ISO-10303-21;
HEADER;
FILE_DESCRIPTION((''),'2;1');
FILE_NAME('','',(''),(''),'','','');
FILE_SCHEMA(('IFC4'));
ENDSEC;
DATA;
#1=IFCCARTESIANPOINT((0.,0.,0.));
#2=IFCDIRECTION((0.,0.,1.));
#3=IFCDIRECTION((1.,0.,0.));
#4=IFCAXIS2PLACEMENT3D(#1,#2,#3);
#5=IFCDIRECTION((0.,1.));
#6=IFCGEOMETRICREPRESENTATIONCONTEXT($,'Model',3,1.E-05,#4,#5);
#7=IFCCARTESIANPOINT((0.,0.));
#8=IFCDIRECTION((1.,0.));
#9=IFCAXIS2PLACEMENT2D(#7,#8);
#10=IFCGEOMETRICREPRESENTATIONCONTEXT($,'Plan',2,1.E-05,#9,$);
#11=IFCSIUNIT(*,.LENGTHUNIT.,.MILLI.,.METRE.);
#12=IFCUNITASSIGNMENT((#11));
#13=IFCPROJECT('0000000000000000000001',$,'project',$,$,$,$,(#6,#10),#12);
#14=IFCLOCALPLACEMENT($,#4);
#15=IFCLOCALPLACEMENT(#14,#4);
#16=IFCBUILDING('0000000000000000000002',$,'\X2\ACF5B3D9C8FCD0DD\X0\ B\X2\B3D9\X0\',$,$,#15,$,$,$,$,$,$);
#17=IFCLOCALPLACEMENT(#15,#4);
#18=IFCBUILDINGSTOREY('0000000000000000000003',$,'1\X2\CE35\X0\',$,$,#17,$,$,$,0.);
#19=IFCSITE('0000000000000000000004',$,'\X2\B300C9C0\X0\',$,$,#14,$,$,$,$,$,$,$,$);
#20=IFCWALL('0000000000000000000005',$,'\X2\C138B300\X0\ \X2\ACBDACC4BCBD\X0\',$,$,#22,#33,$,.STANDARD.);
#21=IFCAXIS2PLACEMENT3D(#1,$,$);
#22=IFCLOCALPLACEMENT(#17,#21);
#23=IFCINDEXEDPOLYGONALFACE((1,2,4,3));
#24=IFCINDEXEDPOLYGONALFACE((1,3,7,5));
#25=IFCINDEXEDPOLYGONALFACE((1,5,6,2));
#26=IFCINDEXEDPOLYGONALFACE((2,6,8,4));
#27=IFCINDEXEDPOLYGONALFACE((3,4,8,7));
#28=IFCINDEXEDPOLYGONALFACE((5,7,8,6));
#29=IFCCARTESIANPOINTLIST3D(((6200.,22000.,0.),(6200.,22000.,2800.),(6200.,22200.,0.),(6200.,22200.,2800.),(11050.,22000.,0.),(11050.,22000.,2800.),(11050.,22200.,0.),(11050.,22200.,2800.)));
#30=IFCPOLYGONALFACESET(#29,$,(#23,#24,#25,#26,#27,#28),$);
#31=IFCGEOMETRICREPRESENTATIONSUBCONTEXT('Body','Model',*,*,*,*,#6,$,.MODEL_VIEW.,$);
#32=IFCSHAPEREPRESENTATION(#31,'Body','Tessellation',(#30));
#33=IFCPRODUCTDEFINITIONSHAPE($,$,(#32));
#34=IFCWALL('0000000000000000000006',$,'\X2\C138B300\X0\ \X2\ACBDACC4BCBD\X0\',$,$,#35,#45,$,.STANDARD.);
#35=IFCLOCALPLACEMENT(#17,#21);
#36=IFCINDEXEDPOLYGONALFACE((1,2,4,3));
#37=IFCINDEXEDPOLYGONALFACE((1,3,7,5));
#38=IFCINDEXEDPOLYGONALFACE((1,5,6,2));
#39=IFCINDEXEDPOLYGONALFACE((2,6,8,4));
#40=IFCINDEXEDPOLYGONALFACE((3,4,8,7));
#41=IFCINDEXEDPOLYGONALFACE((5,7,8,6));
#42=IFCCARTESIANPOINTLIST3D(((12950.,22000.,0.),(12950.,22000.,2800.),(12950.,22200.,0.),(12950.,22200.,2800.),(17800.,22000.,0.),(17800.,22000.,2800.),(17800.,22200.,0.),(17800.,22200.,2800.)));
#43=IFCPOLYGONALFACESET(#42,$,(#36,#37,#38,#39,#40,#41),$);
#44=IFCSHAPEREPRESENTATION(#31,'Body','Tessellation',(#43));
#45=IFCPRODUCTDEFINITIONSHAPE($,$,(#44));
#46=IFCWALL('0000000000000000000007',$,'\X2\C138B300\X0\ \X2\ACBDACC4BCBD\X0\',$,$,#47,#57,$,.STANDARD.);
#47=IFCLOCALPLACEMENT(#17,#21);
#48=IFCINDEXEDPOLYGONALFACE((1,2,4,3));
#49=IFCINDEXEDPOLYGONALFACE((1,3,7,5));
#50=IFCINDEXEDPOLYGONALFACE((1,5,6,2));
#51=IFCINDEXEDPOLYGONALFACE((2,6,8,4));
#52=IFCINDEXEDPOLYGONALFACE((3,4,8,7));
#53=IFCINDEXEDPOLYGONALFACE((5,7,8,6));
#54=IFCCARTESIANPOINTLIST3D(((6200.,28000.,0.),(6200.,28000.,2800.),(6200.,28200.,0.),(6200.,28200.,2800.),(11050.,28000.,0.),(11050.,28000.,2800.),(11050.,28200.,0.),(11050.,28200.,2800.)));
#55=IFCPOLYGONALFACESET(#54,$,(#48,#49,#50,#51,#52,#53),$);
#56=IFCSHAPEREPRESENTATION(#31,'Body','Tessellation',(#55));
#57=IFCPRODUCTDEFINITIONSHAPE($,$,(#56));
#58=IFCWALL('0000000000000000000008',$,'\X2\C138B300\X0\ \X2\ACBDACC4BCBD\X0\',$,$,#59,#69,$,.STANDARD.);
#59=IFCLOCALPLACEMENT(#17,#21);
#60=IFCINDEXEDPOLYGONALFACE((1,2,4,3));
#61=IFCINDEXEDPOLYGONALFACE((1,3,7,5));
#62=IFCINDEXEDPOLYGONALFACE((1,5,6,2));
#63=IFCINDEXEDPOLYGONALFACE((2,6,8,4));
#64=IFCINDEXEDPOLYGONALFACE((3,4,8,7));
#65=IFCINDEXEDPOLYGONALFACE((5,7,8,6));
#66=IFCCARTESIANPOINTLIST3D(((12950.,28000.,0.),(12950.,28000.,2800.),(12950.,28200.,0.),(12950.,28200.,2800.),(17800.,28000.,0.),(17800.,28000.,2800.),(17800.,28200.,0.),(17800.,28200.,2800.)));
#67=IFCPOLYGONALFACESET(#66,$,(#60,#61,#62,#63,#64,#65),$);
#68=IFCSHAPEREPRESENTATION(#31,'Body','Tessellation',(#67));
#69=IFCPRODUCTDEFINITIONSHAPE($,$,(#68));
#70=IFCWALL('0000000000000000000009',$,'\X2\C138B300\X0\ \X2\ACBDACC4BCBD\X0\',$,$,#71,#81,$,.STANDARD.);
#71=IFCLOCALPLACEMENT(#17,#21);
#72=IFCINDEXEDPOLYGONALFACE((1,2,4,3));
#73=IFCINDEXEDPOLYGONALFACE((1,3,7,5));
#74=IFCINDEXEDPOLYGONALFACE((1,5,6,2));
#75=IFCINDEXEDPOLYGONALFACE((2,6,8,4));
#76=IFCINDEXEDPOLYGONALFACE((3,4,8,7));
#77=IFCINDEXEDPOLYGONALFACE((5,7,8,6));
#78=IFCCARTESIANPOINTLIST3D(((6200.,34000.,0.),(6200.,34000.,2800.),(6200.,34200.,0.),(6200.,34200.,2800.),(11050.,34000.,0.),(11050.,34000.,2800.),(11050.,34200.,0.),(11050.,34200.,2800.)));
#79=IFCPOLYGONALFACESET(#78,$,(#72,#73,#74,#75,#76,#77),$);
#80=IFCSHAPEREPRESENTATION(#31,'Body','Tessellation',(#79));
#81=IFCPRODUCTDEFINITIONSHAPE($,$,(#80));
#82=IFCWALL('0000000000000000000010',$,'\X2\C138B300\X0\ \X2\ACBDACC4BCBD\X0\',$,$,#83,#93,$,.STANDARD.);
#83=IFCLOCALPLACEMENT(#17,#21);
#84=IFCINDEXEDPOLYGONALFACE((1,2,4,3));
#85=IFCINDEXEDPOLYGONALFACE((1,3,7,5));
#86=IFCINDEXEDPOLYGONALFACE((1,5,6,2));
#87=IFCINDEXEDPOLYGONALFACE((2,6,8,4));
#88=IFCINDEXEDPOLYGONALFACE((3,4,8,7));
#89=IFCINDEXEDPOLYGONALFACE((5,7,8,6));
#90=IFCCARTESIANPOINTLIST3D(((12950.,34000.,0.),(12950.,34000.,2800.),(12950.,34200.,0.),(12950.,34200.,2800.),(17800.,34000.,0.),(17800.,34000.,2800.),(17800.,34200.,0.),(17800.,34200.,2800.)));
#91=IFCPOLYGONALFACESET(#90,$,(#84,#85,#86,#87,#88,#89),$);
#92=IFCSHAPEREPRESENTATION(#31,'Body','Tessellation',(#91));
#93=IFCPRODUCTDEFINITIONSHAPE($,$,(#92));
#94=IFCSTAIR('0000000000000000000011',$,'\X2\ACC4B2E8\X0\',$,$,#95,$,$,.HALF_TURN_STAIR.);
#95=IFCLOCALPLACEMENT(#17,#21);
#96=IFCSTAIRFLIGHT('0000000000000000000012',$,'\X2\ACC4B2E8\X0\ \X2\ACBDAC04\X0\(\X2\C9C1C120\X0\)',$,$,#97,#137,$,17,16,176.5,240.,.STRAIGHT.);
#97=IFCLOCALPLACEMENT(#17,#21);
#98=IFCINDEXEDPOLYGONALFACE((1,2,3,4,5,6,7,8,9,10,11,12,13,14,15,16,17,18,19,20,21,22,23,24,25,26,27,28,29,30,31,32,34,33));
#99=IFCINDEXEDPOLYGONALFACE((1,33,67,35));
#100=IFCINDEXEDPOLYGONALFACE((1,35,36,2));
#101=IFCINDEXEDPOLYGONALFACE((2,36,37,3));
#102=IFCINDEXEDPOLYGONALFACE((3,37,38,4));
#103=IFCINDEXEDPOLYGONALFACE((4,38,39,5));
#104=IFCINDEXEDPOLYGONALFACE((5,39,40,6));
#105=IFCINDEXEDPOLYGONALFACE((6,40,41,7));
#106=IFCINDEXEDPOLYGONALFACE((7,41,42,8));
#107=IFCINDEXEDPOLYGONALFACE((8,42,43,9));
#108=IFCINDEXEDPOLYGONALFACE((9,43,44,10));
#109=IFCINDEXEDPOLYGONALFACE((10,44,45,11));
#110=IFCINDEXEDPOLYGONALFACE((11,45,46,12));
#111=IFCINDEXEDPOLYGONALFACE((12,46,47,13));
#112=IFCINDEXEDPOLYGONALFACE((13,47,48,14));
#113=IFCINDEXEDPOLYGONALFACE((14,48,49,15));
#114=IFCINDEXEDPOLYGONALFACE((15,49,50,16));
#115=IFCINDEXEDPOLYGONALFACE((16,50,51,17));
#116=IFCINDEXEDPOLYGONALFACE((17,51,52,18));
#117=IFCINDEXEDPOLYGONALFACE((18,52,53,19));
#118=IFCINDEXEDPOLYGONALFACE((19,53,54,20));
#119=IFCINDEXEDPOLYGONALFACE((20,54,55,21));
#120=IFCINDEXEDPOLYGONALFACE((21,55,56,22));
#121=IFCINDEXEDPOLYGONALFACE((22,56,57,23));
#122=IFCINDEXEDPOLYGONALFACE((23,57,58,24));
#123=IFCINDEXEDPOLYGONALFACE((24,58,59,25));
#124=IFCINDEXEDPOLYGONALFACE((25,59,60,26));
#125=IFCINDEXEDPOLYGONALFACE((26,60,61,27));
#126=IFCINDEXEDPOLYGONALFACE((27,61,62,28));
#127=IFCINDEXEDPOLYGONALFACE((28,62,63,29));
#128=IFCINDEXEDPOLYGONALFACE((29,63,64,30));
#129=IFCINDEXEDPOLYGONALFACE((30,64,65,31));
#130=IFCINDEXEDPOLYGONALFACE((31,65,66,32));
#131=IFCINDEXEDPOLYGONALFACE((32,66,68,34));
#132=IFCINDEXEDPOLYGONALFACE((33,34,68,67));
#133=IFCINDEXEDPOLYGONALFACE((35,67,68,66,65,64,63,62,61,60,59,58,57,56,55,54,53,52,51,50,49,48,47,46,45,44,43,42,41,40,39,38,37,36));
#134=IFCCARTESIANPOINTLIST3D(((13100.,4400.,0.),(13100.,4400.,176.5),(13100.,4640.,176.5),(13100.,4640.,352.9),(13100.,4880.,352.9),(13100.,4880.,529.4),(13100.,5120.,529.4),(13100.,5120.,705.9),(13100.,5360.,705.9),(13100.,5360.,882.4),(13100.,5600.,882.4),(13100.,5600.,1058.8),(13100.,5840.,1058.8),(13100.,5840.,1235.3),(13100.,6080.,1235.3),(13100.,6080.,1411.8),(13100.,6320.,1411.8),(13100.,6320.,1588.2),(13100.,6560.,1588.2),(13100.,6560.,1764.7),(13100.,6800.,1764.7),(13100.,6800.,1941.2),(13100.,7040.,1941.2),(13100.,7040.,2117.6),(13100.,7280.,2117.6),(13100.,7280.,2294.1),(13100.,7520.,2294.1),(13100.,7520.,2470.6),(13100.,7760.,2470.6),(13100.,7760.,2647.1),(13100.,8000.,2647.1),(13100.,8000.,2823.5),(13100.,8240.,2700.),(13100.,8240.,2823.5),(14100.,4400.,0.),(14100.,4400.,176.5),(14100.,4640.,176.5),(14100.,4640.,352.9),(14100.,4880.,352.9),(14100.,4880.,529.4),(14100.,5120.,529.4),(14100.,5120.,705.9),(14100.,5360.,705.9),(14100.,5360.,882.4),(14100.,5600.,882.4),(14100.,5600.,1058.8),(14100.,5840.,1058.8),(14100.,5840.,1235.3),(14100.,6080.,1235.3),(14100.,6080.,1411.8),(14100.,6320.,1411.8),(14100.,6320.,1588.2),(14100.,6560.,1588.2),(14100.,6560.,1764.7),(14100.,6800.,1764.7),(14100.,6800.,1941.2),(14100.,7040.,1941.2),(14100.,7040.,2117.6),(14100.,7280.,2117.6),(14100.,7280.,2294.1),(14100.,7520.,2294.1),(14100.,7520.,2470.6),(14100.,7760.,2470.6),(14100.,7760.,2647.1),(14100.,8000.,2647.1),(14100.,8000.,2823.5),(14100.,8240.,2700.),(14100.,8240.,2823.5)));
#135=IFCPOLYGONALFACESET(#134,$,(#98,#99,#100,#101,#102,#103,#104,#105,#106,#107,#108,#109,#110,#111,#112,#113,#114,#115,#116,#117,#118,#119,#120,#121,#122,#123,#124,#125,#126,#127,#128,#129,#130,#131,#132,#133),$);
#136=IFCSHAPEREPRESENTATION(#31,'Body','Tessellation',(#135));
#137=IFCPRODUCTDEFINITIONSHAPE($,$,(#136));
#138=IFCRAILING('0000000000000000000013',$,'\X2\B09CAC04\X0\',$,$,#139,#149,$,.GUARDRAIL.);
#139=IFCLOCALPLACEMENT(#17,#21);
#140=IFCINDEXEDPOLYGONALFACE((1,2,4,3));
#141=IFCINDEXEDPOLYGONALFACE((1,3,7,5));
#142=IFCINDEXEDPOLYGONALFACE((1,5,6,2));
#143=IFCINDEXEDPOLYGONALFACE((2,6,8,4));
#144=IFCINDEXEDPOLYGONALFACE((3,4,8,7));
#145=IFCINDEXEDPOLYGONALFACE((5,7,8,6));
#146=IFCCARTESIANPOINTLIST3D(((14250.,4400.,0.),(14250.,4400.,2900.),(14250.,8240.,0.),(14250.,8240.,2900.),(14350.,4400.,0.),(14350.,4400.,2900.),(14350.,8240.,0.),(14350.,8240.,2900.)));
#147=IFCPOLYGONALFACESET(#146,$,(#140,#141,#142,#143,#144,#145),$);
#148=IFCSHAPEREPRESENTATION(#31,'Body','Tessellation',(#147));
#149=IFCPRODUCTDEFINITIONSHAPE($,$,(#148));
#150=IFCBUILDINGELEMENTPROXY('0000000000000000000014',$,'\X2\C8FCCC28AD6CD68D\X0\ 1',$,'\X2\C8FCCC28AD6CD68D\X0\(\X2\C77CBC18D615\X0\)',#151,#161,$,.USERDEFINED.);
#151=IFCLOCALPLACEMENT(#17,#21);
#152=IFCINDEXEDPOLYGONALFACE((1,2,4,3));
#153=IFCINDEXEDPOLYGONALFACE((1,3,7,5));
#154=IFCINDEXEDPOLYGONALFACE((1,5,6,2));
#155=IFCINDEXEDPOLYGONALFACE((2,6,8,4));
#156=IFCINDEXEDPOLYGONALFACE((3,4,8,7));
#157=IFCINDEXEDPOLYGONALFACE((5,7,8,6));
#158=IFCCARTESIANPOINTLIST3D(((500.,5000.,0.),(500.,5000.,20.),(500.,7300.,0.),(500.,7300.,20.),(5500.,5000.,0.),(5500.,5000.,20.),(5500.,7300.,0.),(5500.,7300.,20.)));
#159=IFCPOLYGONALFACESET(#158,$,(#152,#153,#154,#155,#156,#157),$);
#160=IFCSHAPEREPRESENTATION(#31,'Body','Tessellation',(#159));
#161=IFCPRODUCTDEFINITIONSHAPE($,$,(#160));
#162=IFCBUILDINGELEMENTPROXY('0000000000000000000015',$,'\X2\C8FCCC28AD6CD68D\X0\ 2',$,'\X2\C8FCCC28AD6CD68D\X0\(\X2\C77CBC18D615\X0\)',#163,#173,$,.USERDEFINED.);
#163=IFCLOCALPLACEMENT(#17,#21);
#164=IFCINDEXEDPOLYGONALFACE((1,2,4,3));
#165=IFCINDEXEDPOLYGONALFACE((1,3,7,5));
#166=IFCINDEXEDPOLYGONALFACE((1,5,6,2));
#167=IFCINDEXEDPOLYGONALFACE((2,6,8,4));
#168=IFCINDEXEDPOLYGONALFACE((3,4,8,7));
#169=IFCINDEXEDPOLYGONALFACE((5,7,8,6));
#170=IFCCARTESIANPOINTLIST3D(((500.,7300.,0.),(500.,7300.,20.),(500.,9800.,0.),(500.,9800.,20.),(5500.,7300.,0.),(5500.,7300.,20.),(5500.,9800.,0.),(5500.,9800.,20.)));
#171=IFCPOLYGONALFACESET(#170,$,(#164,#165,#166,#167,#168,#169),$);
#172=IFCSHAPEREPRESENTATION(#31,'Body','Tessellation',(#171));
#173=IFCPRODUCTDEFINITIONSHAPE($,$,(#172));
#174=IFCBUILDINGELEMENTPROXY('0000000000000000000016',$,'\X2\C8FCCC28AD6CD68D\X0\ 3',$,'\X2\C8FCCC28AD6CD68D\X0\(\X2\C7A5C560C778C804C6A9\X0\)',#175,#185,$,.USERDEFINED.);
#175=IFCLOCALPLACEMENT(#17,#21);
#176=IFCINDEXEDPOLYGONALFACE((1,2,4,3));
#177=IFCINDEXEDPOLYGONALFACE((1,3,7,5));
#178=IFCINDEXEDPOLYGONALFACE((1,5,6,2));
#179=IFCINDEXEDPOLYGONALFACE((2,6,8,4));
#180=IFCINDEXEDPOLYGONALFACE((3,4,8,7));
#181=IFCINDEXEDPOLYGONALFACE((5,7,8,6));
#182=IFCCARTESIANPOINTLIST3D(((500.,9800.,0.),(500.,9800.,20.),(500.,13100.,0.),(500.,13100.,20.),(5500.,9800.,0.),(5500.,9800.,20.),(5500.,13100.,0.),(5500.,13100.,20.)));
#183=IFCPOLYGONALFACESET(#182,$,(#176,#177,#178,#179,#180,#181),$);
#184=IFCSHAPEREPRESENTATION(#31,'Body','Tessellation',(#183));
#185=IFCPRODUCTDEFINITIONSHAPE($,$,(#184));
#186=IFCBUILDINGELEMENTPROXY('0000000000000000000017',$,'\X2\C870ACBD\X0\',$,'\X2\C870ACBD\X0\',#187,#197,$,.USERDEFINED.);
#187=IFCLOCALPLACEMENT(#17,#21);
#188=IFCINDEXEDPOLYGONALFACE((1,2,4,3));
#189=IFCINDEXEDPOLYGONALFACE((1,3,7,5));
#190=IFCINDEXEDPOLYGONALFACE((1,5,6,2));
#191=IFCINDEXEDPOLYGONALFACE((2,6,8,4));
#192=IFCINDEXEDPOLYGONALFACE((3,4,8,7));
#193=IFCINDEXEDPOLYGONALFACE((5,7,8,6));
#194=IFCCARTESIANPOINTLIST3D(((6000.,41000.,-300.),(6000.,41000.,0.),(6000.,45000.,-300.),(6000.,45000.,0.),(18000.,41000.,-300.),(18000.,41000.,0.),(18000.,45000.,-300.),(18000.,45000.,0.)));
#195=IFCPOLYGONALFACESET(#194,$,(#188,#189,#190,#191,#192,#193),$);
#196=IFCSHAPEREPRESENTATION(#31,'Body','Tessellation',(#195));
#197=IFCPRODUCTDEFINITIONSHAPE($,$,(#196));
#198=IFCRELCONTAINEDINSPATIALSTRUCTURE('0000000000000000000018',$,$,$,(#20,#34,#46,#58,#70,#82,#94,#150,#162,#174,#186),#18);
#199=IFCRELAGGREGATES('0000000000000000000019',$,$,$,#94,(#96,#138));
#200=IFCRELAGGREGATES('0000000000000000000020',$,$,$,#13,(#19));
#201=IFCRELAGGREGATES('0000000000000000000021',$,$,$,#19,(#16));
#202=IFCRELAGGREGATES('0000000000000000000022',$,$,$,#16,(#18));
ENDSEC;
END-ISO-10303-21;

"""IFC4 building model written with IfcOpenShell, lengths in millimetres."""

from ifc_helpers import new_model, si_unit, direction, frame, origin_with_axes, origin_2d_with_axis, place, context, subcontext, project, spatial, polyline, outline, extrude, element, aggregate, save


model = new_model("IFC4")

# Units and contexts
model_context = context("Model", 3, precision=1e-05, world=origin_with_axes(), true_north=direction((0.0, 1.0)))
plan_context = context("Plan", 2, precision=1e-05, world=origin_2d_with_axis())
body_context = subcontext(model_context, "Body", "Model", "MODEL_VIEW")
ifc_project = project(units=[si_unit("LENGTHUNIT", "METRE", prefix="MILLI")], contexts=[model_context, plan_context])

# Site, building, storey
site_placement = place(None, origin_with_axes())
site = spatial("IfcSite", under=ifc_project, at=site_placement, Name="대지")
building_placement = place(site_placement, origin_with_axes())
building = spatial("IfcBuilding", under=site, at=building_placement, Name="공동주택 B동")
storey_placement = place(building_placement, origin_with_axes())
storey = spatial("IfcBuildingStorey", under=building, at=storey_placement, Name="1층", Elevation=0.0)

# Walls
wall_1_placement = place(storey_placement, origin_with_axes())
element("IfcWall", 1, at=wall_1_placement, inside=storey, Name="세대 경계벽", PredefinedType="STANDARD", context=body_context, shape_type="SweptSolid", body=[
    extrude(outline(polyline([(6200.0, 22200.0), (11050.0, 22200.0), (11050.0, 22000.0), (6200.0, 22000.0), (6200.0, 22200.0)])), origin_with_axes(), (0.0, 0.0, 1.0), 2800.0),
])
wall_2_placement = place(storey_placement, origin_with_axes())
element("IfcWall", 2, at=wall_2_placement, inside=storey, Name="세대 경계벽", PredefinedType="STANDARD", context=body_context, shape_type="SweptSolid", body=[
    extrude(outline(polyline([(12950.0, 22200.0), (17800.0, 22200.0), (17800.0, 22000.0), (12950.0, 22000.0), (12950.0, 22200.0)])), origin_with_axes(), (0.0, 0.0, 1.0), 2800.0),
])
wall_3_placement = place(storey_placement, origin_with_axes())
element("IfcWall", 3, at=wall_3_placement, inside=storey, Name="세대 경계벽", PredefinedType="STANDARD", context=body_context, shape_type="SweptSolid", body=[
    extrude(outline(polyline([(6200.0, 28200.0), (11050.0, 28200.0), (11050.0, 28000.0), (6200.0, 28000.0), (6200.0, 28200.0)])), origin_with_axes(), (0.0, 0.0, 1.0), 2800.0),
])
wall_4_placement = place(storey_placement, origin_with_axes())
element("IfcWall", 4, at=wall_4_placement, inside=storey, Name="세대 경계벽", PredefinedType="STANDARD", context=body_context, shape_type="SweptSolid", body=[
    extrude(outline(polyline([(12950.0, 28200.0), (17800.0, 28200.0), (17800.0, 28000.0), (12950.0, 28000.0), (12950.0, 28200.0)])), origin_with_axes(), (0.0, 0.0, 1.0), 2800.0),
])
wall_5_placement = place(storey_placement, origin_with_axes())
element("IfcWall", 5, at=wall_5_placement, inside=storey, Name="세대 경계벽", PredefinedType="STANDARD", context=body_context, shape_type="SweptSolid", body=[
    extrude(outline(polyline([(6200.0, 34200.0), (11050.0, 34200.0), (11050.0, 34000.0), (6200.0, 34000.0), (6200.0, 34200.0)])), origin_with_axes(), (0.0, 0.0, 1.0), 2800.0),
])
wall_6_placement = place(storey_placement, origin_with_axes())
element("IfcWall", 6, at=wall_6_placement, inside=storey, Name="세대 경계벽", PredefinedType="STANDARD", context=body_context, shape_type="SweptSolid", body=[
    extrude(outline(polyline([(12950.0, 34200.0), (17800.0, 34200.0), (17800.0, 34000.0), (12950.0, 34000.0), (12950.0, 34200.0)])), origin_with_axes(), (0.0, 0.0, 1.0), 2800.0),
])

# Stair, stair flight, railing
stair_placement = place(storey_placement, origin_with_axes())
stair = element("IfcStair", 7, at=stair_placement, inside=storey, Name="계단", PredefinedType="HALF_TURN_STAIR")
stair_flight_placement = place(stair_placement, origin_with_axes())
stair_flight = element("IfcStairFlight", 8, at=stair_flight_placement, Name="계단 경간(직선)", NumberOfRisers=17, NumberOfTreads=16, PredefinedType="STRAIGHT", RiserHeight=176.5, TreadLength=240.0, context=body_context, shape_type="SweptSolid", body=[
    extrude(outline(polyline([(0.0, 0.0), (0.0, 176.5), (240.0, 176.5), (240.0, 352.9), (480.0, 352.9), (480.0, 529.4), (720.0, 529.4), (720.0, 705.9), (960.0, 705.9), (960.0, 882.4), (1200.0, 882.4), (1200.0, 1058.8), (1440.0, 1058.8), (1440.0, 1235.3), (1680.0, 1235.3), (1680.0, 1411.8), (1920.0, 1411.8), (1920.0, 1588.2), (2160.0, 1588.2), (2160.0, 1764.7), (2400.0, 1764.7), (2400.0, 1941.2), (2640.0, 1941.2), (2640.0, 2117.6), (2880.0, 2117.6), (2880.0, 2294.1), (3120.0, 2294.1), (3120.0, 2470.6), (3360.0, 2470.6), (3360.0, 2647.1), (3600.0, 2647.1), (3600.0, 2823.5), (3840.0, 2823.5), (3840.0, 3000.0), (3840.0, 2700.0), (0.0, 0.0)])), frame((13100.0, 4400.0, 0.0), z_axis=(1.0, 0.0, 0.0), x_axis=(0.0, 1.0, 0.0)), (0.0, 0.0, 1.0), 1000.0),
])
railing_placement = place(stair_placement, origin_with_axes())
railing = element("IfcRailing", 9, at=railing_placement, Name="난간", PredefinedType="GUARDRAIL", context=body_context, shape_type="SweptSolid", body=[
    extrude(outline(polyline([(14250.0, 4400.0), (14350.0, 4400.0), (14350.0, 8240.0), (14250.0, 8240.0), (14250.0, 4400.0)])), origin_with_axes(), (0.0, 0.0, 1.0), 2900.0),
])
aggregate(stair, [stair_flight, railing])

# Building element proxies
proxy_1_placement = place(storey_placement, origin_with_axes())
element("IfcBuildingElementProxy", 10, at=proxy_1_placement, inside=storey, Name="주차구획 1", ObjectType="주차구획(일반형)", PredefinedType="USERDEFINED", context=body_context, shape_type="SweptSolid", body=[
    extrude(outline(polyline([(500.0, 5000.0), (5500.0, 5000.0), (5500.0, 7300.0), (500.0, 7300.0), (500.0, 5000.0)])), origin_with_axes(), (0.0, 0.0, 1.0), 20.0),
])
proxy_2_placement = place(storey_placement, origin_with_axes())
element("IfcBuildingElementProxy", 11, at=proxy_2_placement, inside=storey, Name="주차구획 2", ObjectType="주차구획(일반형)", PredefinedType="USERDEFINED", context=body_context, shape_type="SweptSolid", body=[
    extrude(outline(polyline([(500.0, 7300.0), (5500.0, 7300.0), (5500.0, 9800.0), (500.0, 9800.0), (500.0, 7300.0)])), origin_with_axes(), (0.0, 0.0, 1.0), 20.0),
])
proxy_3_placement = place(storey_placement, origin_with_axes())
element("IfcBuildingElementProxy", 12, at=proxy_3_placement, inside=storey, Name="주차구획 3", ObjectType="주차구획(장애인전용)", PredefinedType="USERDEFINED", context=body_context, shape_type="SweptSolid", body=[
    extrude(outline(polyline([(500.0, 9800.0), (5500.0, 9800.0), (5500.0, 13100.0), (500.0, 13100.0), (500.0, 9800.0)])), origin_with_axes(), (0.0, 0.0, 1.0), 20.0),
])
proxy_4_placement = place(storey_placement, origin_with_axes())
element("IfcBuildingElementProxy", 13, at=proxy_4_placement, inside=storey, Name="조경", ObjectType="조경", PredefinedType="USERDEFINED", context=body_context, shape_type="SweptSolid", body=[
    extrude(outline(polyline([(6000.0, 41000.0), (18000.0, 41000.0), (18000.0, 45000.0), (6000.0, 45000.0), (6000.0, 41000.0)])), frame((0.0, 0.0, -300.0), z_axis=(0.0, 0.0, 1.0), x_axis=(1.0, 0.0, 0.0)), (0.0, 0.0, 1.0), 300.0),
])

save(model, "model.ifc")
